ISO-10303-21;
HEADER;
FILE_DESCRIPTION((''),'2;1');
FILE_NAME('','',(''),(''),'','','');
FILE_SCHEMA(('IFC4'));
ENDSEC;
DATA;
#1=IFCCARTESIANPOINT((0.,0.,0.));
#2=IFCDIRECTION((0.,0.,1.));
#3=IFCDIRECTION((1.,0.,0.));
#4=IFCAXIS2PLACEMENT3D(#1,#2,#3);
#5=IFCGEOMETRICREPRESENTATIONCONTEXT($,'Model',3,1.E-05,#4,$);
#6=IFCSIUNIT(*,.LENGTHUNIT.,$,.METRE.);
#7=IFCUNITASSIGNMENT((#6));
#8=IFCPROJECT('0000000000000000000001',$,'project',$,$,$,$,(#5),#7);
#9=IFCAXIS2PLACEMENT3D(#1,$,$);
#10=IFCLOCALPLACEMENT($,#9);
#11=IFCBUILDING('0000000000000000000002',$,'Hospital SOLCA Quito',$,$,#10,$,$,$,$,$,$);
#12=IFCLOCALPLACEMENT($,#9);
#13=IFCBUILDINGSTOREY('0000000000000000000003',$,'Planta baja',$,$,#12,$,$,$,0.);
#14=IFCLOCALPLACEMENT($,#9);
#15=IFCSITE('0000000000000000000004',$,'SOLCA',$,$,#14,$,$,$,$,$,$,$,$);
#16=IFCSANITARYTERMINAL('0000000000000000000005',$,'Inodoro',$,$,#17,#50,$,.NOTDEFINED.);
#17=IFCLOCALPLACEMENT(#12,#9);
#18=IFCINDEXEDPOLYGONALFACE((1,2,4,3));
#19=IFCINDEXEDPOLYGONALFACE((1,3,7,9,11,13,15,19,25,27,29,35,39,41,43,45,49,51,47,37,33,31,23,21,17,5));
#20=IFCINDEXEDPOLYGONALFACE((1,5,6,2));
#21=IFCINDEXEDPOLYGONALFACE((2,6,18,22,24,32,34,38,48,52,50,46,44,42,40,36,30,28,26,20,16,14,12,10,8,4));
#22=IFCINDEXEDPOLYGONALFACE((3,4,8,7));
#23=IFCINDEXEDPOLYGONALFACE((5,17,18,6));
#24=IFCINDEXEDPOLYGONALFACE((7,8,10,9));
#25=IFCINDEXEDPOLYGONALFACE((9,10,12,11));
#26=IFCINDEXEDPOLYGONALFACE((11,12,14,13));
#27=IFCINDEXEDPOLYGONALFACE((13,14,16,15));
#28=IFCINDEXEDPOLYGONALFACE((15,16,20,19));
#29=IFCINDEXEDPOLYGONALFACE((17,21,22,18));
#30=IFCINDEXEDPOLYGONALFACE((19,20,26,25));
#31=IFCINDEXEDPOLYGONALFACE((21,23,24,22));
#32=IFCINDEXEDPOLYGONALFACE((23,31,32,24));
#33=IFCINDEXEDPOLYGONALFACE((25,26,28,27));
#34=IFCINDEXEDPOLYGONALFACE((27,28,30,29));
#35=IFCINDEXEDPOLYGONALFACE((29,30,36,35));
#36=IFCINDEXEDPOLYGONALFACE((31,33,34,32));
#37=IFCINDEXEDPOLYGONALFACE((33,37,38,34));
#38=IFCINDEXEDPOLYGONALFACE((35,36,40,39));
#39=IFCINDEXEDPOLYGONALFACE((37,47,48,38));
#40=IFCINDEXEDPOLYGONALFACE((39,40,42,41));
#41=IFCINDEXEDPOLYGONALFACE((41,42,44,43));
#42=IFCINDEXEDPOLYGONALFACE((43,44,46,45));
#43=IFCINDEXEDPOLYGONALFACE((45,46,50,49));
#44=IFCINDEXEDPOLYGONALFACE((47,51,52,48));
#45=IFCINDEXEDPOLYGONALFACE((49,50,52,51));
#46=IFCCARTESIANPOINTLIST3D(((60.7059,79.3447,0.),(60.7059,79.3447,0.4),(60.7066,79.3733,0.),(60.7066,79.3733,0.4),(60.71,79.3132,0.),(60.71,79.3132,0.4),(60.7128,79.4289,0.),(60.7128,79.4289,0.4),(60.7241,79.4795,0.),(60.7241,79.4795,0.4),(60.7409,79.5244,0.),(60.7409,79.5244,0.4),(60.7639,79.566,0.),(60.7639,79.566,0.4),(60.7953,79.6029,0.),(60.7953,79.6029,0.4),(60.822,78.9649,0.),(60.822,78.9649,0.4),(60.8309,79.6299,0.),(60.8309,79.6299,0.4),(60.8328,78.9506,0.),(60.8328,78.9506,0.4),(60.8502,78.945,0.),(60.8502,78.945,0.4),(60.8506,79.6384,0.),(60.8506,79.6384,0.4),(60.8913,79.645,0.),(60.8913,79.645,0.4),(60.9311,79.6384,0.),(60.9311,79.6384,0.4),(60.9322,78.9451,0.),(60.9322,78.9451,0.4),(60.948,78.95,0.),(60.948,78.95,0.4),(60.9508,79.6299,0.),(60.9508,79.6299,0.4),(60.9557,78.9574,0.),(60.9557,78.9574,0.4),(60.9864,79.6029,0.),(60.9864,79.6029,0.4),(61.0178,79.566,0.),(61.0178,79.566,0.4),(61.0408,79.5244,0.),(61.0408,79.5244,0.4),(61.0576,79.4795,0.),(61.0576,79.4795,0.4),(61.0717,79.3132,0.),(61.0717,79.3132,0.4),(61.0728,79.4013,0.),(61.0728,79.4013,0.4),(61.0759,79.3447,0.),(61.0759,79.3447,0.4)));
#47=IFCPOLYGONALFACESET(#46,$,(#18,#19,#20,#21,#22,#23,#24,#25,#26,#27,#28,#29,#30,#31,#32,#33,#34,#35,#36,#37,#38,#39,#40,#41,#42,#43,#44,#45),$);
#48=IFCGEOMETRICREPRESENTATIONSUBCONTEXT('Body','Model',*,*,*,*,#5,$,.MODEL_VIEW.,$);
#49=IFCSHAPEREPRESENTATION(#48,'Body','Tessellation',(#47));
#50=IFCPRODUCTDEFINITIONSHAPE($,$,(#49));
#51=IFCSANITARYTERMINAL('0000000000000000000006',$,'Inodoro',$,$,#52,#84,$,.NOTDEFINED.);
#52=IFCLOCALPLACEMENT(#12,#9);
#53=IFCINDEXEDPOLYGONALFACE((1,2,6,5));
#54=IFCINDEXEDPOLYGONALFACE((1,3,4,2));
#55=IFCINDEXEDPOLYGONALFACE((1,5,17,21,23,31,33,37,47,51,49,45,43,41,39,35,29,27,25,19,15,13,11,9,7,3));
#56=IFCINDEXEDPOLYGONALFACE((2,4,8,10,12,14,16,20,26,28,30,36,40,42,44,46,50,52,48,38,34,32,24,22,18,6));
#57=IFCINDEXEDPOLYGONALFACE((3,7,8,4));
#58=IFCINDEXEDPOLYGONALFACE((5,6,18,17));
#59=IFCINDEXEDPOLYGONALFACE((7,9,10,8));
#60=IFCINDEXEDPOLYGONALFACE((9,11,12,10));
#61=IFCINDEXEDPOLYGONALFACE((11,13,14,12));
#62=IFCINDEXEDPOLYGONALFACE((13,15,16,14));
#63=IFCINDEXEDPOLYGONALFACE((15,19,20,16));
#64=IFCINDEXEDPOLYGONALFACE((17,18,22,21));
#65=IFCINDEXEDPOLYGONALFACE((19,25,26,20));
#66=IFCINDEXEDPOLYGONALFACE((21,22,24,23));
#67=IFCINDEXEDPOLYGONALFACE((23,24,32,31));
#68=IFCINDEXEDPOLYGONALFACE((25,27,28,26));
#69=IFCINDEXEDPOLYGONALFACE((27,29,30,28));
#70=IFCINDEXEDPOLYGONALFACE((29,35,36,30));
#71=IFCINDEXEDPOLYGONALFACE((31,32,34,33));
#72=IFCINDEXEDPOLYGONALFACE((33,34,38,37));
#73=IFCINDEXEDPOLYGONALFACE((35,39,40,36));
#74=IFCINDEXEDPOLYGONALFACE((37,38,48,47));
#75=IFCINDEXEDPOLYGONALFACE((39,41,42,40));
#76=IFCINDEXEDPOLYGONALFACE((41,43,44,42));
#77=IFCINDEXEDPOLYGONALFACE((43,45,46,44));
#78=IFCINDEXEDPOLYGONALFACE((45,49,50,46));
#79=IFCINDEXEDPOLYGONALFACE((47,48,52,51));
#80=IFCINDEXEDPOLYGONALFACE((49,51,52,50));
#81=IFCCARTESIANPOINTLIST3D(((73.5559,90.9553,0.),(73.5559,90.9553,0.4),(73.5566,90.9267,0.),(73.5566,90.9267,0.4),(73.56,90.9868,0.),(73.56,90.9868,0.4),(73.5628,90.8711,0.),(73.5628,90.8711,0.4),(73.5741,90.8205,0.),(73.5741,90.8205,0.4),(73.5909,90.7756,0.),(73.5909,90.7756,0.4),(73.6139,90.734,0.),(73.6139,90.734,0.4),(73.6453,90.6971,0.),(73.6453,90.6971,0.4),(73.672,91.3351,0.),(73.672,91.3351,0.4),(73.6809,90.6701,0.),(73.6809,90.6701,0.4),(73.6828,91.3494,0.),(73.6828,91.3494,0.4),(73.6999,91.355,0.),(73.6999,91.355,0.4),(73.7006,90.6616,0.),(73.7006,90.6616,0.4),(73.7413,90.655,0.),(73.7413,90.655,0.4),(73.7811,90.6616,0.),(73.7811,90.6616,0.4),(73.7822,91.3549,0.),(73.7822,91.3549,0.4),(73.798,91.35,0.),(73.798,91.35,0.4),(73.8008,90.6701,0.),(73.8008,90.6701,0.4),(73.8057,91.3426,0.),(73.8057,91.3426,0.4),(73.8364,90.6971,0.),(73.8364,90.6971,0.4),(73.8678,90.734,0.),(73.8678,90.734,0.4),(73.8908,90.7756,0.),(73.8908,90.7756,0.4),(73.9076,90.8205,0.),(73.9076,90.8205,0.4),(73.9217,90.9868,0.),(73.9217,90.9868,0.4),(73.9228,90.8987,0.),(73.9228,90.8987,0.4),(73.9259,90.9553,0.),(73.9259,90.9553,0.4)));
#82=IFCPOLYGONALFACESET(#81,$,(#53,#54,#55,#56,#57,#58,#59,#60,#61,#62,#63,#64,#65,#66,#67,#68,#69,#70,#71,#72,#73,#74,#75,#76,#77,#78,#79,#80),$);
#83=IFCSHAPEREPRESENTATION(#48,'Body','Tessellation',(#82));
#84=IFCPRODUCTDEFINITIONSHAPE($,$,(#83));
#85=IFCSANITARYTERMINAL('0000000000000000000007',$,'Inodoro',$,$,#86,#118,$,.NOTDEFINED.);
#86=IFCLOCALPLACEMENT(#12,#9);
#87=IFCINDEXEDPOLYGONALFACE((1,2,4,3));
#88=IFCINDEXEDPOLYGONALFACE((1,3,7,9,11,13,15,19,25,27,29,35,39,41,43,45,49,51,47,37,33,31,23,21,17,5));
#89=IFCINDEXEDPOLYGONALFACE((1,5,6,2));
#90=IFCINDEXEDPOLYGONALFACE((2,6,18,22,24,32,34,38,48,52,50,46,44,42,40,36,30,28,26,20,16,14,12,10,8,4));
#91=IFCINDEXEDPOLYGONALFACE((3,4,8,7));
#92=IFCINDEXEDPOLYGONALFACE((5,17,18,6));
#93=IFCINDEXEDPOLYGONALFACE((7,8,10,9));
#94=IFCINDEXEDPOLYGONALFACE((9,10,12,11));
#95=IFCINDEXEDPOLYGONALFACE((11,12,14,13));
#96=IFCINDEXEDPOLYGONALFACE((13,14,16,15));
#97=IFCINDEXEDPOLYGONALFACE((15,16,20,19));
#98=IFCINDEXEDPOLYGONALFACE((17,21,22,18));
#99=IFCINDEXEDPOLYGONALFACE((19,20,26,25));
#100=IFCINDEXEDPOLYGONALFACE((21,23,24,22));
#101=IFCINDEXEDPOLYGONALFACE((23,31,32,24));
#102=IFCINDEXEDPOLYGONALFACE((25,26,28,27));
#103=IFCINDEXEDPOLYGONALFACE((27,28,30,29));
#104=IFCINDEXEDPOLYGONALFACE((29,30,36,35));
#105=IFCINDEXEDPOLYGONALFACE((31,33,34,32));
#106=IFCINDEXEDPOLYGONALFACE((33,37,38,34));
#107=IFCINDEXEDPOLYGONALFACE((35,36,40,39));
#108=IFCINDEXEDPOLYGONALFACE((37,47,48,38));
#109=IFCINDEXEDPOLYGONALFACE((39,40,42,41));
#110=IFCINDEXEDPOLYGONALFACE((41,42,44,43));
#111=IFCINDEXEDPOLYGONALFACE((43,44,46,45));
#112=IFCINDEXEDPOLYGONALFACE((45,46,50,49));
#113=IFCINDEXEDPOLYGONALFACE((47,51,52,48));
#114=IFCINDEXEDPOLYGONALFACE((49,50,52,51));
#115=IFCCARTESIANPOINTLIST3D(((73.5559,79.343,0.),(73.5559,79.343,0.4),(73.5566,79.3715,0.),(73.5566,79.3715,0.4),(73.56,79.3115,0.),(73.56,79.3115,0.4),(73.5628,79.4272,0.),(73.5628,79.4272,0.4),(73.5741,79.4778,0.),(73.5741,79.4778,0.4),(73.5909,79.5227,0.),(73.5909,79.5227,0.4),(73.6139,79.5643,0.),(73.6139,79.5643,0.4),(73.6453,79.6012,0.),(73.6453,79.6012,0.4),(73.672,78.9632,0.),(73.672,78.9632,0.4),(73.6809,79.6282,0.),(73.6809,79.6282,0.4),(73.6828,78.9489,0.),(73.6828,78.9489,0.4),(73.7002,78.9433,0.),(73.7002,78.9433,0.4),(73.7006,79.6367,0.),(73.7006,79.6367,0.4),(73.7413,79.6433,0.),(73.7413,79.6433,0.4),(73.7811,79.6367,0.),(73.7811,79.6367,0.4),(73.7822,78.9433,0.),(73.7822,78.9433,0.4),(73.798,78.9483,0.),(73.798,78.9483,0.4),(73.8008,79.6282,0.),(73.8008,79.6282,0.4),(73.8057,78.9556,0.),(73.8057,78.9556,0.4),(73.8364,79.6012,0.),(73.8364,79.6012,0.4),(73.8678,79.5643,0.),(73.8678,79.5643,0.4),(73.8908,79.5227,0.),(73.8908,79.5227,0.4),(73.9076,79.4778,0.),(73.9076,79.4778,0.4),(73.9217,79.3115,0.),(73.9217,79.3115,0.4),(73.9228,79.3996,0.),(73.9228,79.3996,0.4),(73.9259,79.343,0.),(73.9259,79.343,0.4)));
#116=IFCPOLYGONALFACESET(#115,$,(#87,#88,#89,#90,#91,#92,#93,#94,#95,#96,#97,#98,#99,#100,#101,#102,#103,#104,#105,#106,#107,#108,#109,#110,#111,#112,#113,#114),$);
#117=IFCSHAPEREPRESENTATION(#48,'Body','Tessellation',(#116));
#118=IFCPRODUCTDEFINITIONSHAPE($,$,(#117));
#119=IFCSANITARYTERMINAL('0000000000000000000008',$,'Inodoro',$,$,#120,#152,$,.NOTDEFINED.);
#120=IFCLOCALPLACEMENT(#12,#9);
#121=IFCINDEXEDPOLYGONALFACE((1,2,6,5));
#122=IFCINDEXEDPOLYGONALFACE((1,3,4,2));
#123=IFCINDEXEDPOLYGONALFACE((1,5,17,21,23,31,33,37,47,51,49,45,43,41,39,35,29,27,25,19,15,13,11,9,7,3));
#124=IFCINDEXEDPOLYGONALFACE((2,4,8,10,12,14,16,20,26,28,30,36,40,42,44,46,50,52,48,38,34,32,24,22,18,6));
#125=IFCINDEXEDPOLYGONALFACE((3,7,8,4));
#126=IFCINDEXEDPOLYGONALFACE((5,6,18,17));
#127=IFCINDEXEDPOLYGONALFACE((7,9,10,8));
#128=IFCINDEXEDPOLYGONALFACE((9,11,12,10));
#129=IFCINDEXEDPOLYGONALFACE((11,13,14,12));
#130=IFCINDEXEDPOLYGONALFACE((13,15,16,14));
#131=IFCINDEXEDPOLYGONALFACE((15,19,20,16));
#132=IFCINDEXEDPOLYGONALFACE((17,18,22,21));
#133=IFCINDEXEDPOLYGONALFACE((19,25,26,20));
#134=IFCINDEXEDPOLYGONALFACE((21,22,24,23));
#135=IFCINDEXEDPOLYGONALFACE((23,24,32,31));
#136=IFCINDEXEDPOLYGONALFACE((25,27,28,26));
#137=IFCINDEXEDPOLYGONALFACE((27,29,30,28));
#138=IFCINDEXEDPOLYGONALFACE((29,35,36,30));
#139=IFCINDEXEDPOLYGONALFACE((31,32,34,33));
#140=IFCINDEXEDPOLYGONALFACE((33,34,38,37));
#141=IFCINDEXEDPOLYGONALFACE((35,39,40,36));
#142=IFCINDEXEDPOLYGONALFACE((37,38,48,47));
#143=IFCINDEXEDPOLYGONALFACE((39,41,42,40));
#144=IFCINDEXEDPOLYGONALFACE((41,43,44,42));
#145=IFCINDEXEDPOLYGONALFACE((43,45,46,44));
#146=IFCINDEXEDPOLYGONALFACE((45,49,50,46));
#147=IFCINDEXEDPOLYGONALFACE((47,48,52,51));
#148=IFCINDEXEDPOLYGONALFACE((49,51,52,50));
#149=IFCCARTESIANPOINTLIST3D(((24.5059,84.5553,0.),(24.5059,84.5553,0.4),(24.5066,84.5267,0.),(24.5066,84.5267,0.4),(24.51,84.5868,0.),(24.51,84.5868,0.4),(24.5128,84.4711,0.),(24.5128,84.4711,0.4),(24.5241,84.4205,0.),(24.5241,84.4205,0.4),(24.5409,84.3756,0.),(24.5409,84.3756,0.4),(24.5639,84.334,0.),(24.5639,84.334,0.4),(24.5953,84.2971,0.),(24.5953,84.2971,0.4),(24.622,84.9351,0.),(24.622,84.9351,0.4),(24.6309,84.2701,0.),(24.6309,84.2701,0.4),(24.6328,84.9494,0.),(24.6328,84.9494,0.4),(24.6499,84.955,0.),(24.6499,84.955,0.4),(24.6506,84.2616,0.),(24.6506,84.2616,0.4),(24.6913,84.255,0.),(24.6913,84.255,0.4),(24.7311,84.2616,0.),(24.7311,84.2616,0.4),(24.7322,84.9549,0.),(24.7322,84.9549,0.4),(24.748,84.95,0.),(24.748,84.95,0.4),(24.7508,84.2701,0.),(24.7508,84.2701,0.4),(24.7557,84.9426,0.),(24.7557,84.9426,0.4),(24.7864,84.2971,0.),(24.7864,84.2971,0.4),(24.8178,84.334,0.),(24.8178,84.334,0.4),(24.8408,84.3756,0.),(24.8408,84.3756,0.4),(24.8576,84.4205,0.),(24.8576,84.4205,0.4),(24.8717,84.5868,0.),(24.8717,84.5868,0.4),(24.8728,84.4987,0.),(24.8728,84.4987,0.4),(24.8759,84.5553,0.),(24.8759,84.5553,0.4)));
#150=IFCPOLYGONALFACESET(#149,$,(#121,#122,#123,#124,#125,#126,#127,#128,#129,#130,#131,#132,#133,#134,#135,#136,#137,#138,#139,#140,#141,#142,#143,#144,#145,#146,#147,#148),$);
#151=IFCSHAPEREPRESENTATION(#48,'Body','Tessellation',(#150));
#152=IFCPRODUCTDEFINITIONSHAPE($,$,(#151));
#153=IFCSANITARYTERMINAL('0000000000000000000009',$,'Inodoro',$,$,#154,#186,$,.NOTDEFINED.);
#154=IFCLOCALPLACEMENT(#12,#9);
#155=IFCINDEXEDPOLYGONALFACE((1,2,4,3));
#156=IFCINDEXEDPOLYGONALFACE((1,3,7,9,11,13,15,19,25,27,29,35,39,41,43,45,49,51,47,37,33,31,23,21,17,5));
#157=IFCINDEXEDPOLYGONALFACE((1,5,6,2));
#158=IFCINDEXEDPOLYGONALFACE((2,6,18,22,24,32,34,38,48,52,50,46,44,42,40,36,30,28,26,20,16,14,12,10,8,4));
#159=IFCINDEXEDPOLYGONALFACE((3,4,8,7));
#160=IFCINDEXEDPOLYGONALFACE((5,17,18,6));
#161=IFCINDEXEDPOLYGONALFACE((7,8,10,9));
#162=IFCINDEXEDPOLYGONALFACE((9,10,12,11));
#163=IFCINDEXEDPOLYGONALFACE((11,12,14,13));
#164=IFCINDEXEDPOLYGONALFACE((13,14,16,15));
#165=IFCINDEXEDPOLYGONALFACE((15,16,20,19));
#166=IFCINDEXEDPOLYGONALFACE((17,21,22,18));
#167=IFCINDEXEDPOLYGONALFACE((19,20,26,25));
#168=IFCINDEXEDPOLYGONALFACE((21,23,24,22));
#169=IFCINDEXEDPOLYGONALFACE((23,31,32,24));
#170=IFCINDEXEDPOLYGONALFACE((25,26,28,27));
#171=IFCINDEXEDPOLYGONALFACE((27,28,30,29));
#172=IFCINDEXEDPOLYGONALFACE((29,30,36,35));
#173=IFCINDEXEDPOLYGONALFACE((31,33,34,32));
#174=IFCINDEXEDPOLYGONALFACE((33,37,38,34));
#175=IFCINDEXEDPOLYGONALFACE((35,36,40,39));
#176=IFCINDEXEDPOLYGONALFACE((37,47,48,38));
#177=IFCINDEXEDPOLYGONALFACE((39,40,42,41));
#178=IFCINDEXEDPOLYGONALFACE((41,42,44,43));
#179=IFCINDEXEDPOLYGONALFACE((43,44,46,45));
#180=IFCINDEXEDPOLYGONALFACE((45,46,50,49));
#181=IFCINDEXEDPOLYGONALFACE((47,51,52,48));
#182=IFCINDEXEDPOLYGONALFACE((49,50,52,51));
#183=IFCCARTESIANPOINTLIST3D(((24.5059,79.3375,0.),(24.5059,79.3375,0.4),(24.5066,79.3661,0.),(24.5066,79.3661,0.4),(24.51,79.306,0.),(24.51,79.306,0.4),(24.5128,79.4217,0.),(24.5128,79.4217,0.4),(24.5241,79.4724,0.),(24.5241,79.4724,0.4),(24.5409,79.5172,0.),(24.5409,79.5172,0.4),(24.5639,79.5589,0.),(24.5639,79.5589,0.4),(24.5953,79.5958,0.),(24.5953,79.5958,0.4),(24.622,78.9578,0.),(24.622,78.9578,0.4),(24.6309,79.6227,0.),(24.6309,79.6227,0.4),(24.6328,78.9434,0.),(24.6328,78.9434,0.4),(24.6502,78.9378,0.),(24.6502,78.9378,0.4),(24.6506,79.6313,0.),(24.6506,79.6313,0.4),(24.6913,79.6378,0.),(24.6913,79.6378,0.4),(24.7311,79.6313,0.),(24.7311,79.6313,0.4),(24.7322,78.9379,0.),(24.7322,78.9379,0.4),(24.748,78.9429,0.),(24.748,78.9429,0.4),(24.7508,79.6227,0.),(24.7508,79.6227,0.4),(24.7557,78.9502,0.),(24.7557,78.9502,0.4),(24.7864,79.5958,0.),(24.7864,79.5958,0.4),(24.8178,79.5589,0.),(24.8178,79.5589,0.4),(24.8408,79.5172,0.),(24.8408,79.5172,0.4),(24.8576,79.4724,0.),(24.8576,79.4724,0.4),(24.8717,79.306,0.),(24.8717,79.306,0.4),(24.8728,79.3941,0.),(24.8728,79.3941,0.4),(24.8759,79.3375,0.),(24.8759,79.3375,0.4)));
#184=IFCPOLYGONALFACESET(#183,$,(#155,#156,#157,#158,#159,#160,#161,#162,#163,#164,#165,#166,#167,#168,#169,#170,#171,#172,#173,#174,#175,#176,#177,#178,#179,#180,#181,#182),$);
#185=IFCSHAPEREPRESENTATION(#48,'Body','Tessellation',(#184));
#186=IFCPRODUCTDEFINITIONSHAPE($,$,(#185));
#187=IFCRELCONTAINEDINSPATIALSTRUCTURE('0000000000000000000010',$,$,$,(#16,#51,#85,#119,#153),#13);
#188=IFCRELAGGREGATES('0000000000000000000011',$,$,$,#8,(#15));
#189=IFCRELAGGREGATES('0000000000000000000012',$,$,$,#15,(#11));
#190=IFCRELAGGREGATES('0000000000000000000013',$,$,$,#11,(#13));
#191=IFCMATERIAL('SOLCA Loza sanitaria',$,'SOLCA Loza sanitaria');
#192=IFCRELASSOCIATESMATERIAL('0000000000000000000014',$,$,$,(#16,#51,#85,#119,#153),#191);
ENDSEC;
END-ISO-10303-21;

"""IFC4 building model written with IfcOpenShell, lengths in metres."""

from ifc_helpers import new_model, si_unit, origin, origin_with_axes, place, context, subcontext, project, spatial, polyline, outline, extrude, material, element, save


model = new_model("IFC4")

# Units and contexts
model_context = context("Model", 3, precision=1e-05, world=origin_with_axes())
body_context = subcontext(model_context, "Body", "Model", "MODEL_VIEW")
ifc_project = project(units=[si_unit("LENGTHUNIT", "METRE")], contexts=[model_context])

# Site, building, storey
site_placement = place(None, origin())
site = spatial("IfcSite", under=ifc_project, at=site_placement, Name="SOLCA")
building_placement = place(None, origin())
building = spatial("IfcBuilding", under=site, at=building_placement, Name="Hospital SOLCA Quito")
storey_placement = place(None, origin())
storey = spatial("IfcBuildingStorey", under=building, at=storey_placement, Name="Planta baja", Elevation=0.0)

# Sanitary terminals
ifc_material = material(Name="SOLCA Loza sanitaria", Category="SOLCA Loza sanitaria")
sanitary_terminal_1_placement = place(storey_placement, origin_with_axes())
element("IfcSanitaryTerminal", 1, at=sanitary_terminal_1_placement, inside=storey, material=ifc_material, Name="Inodoro", PredefinedType="NOTDEFINED", context=body_context, shape_type="SweptSolid", body=[
    extrude(outline(polyline([(60.8502, 78.945), (60.8328, 78.9506), (60.822, 78.9649), (60.71, 79.3132), (60.7059, 79.3447), (60.7066, 79.3733), (60.7128, 79.4289), (60.7241, 79.4795), (60.7409, 79.5244), (60.7639, 79.566), (60.7953, 79.6029), (60.8309, 79.6299), (60.8506, 79.6384), (60.8913, 79.645), (60.9311, 79.6384), (60.9508, 79.6299), (60.9864, 79.6029), (61.0178, 79.566), (61.0408, 79.5244), (61.0576, 79.4795), (61.0728, 79.4013), (61.0759, 79.3447), (61.0717, 79.3132), (60.9557, 78.9574), (60.948, 78.95), (60.9322, 78.9451), (60.8502, 78.945)])), origin_with_axes(), (0.0, 0.0, 1.0), 0.4),
])
sanitary_terminal_2_placement = place(storey_placement, origin_with_axes())
element("IfcSanitaryTerminal", 2, at=sanitary_terminal_2_placement, inside=storey, material=ifc_material, Name="Inodoro", PredefinedType="NOTDEFINED", context=body_context, shape_type="SweptSolid", body=[
    extrude(outline(polyline([(73.7413, 90.655), (73.7006, 90.6616), (73.6809, 90.6701), (73.6453, 90.6971), (73.6139, 90.734), (73.5909, 90.7756), (73.5741, 90.8205), (73.5628, 90.8711), (73.5566, 90.9267), (73.5559, 90.9553), (73.56, 90.9868), (73.672, 91.3351), (73.6828, 91.3494), (73.6999, 91.355), (73.7822, 91.3549), (73.798, 91.35), (73.8057, 91.3426), (73.9217, 90.9868), (73.9259, 90.9553), (73.9228, 90.8987), (73.9076, 90.8205), (73.8908, 90.7756), (73.8678, 90.734), (73.8364, 90.6971), (73.8008, 90.6701), (73.7811, 90.6616), (73.7413, 90.655)])), origin_with_axes(), (0.0, 0.0, 1.0), 0.4),
])
sanitary_terminal_3_placement = place(storey_placement, origin_with_axes())
element("IfcSanitaryTerminal", 3, at=sanitary_terminal_3_placement, inside=storey, material=ifc_material, Name="Inodoro", PredefinedType="NOTDEFINED", context=body_context, shape_type="SweptSolid", body=[
    extrude(outline(polyline([(73.7002, 78.9433), (73.6828, 78.9489), (73.672, 78.9632), (73.56, 79.3115), (73.5559, 79.343), (73.5566, 79.3715), (73.5628, 79.4272), (73.5741, 79.4778), (73.5909, 79.5227), (73.6139, 79.5643), (73.6453, 79.6012), (73.6809, 79.6282), (73.7006, 79.6367), (73.7413, 79.6433), (73.7811, 79.6367), (73.8008, 79.6282), (73.8364, 79.6012), (73.8678, 79.5643), (73.8908, 79.5227), (73.9076, 79.4778), (73.9228, 79.3996), (73.9259, 79.343), (73.9217, 79.3115), (73.8057, 78.9556), (73.798, 78.9483), (73.7822, 78.9433), (73.7002, 78.9433)])), origin_with_axes(), (0.0, 0.0, 1.0), 0.4),
])
sanitary_terminal_4_placement = place(storey_placement, origin_with_axes())
element("IfcSanitaryTerminal", 4, at=sanitary_terminal_4_placement, inside=storey, material=ifc_material, Name="Inodoro", PredefinedType="NOTDEFINED", context=body_context, shape_type="SweptSolid", body=[
    extrude(outline(polyline([(24.6913, 84.255), (24.6506, 84.2616), (24.6309, 84.2701), (24.5953, 84.2971), (24.5639, 84.334), (24.5409, 84.3756), (24.5241, 84.4205), (24.5128, 84.4711), (24.5066, 84.5267), (24.5059, 84.5553), (24.51, 84.5868), (24.622, 84.9351), (24.6328, 84.9494), (24.6499, 84.955), (24.7322, 84.9549), (24.748, 84.95), (24.7557, 84.9426), (24.8717, 84.5868), (24.8759, 84.5553), (24.8728, 84.4987), (24.8576, 84.4205), (24.8408, 84.3756), (24.8178, 84.334), (24.7864, 84.2971), (24.7508, 84.2701), (24.7311, 84.2616), (24.6913, 84.255)])), origin_with_axes(), (0.0, 0.0, 1.0), 0.4),
])
sanitary_terminal_5_placement = place(storey_placement, origin_with_axes())
element("IfcSanitaryTerminal", 5, at=sanitary_terminal_5_placement, inside=storey, material=ifc_material, Name="Inodoro", PredefinedType="NOTDEFINED", context=body_context, shape_type="SweptSolid", body=[
    extrude(outline(polyline([(24.6502, 78.9378), (24.6328, 78.9434), (24.622, 78.9578), (24.51, 79.306), (24.5059, 79.3375), (24.5066, 79.3661), (24.5128, 79.4217), (24.5241, 79.4724), (24.5409, 79.5172), (24.5639, 79.5589), (24.5953, 79.5958), (24.6309, 79.6227), (24.6506, 79.6313), (24.6913, 79.6378), (24.7311, 79.6313), (24.7508, 79.6227), (24.7864, 79.5958), (24.8178, 79.5589), (24.8408, 79.5172), (24.8576, 79.4724), (24.8728, 79.3941), (24.8759, 79.3375), (24.8717, 79.306), (24.7557, 78.9502), (24.748, 78.9429), (24.7322, 78.9379), (24.6502, 78.9378)])), origin_with_axes(), (0.0, 0.0, 1.0), 0.4),
])

save(model, "model.ifc")
